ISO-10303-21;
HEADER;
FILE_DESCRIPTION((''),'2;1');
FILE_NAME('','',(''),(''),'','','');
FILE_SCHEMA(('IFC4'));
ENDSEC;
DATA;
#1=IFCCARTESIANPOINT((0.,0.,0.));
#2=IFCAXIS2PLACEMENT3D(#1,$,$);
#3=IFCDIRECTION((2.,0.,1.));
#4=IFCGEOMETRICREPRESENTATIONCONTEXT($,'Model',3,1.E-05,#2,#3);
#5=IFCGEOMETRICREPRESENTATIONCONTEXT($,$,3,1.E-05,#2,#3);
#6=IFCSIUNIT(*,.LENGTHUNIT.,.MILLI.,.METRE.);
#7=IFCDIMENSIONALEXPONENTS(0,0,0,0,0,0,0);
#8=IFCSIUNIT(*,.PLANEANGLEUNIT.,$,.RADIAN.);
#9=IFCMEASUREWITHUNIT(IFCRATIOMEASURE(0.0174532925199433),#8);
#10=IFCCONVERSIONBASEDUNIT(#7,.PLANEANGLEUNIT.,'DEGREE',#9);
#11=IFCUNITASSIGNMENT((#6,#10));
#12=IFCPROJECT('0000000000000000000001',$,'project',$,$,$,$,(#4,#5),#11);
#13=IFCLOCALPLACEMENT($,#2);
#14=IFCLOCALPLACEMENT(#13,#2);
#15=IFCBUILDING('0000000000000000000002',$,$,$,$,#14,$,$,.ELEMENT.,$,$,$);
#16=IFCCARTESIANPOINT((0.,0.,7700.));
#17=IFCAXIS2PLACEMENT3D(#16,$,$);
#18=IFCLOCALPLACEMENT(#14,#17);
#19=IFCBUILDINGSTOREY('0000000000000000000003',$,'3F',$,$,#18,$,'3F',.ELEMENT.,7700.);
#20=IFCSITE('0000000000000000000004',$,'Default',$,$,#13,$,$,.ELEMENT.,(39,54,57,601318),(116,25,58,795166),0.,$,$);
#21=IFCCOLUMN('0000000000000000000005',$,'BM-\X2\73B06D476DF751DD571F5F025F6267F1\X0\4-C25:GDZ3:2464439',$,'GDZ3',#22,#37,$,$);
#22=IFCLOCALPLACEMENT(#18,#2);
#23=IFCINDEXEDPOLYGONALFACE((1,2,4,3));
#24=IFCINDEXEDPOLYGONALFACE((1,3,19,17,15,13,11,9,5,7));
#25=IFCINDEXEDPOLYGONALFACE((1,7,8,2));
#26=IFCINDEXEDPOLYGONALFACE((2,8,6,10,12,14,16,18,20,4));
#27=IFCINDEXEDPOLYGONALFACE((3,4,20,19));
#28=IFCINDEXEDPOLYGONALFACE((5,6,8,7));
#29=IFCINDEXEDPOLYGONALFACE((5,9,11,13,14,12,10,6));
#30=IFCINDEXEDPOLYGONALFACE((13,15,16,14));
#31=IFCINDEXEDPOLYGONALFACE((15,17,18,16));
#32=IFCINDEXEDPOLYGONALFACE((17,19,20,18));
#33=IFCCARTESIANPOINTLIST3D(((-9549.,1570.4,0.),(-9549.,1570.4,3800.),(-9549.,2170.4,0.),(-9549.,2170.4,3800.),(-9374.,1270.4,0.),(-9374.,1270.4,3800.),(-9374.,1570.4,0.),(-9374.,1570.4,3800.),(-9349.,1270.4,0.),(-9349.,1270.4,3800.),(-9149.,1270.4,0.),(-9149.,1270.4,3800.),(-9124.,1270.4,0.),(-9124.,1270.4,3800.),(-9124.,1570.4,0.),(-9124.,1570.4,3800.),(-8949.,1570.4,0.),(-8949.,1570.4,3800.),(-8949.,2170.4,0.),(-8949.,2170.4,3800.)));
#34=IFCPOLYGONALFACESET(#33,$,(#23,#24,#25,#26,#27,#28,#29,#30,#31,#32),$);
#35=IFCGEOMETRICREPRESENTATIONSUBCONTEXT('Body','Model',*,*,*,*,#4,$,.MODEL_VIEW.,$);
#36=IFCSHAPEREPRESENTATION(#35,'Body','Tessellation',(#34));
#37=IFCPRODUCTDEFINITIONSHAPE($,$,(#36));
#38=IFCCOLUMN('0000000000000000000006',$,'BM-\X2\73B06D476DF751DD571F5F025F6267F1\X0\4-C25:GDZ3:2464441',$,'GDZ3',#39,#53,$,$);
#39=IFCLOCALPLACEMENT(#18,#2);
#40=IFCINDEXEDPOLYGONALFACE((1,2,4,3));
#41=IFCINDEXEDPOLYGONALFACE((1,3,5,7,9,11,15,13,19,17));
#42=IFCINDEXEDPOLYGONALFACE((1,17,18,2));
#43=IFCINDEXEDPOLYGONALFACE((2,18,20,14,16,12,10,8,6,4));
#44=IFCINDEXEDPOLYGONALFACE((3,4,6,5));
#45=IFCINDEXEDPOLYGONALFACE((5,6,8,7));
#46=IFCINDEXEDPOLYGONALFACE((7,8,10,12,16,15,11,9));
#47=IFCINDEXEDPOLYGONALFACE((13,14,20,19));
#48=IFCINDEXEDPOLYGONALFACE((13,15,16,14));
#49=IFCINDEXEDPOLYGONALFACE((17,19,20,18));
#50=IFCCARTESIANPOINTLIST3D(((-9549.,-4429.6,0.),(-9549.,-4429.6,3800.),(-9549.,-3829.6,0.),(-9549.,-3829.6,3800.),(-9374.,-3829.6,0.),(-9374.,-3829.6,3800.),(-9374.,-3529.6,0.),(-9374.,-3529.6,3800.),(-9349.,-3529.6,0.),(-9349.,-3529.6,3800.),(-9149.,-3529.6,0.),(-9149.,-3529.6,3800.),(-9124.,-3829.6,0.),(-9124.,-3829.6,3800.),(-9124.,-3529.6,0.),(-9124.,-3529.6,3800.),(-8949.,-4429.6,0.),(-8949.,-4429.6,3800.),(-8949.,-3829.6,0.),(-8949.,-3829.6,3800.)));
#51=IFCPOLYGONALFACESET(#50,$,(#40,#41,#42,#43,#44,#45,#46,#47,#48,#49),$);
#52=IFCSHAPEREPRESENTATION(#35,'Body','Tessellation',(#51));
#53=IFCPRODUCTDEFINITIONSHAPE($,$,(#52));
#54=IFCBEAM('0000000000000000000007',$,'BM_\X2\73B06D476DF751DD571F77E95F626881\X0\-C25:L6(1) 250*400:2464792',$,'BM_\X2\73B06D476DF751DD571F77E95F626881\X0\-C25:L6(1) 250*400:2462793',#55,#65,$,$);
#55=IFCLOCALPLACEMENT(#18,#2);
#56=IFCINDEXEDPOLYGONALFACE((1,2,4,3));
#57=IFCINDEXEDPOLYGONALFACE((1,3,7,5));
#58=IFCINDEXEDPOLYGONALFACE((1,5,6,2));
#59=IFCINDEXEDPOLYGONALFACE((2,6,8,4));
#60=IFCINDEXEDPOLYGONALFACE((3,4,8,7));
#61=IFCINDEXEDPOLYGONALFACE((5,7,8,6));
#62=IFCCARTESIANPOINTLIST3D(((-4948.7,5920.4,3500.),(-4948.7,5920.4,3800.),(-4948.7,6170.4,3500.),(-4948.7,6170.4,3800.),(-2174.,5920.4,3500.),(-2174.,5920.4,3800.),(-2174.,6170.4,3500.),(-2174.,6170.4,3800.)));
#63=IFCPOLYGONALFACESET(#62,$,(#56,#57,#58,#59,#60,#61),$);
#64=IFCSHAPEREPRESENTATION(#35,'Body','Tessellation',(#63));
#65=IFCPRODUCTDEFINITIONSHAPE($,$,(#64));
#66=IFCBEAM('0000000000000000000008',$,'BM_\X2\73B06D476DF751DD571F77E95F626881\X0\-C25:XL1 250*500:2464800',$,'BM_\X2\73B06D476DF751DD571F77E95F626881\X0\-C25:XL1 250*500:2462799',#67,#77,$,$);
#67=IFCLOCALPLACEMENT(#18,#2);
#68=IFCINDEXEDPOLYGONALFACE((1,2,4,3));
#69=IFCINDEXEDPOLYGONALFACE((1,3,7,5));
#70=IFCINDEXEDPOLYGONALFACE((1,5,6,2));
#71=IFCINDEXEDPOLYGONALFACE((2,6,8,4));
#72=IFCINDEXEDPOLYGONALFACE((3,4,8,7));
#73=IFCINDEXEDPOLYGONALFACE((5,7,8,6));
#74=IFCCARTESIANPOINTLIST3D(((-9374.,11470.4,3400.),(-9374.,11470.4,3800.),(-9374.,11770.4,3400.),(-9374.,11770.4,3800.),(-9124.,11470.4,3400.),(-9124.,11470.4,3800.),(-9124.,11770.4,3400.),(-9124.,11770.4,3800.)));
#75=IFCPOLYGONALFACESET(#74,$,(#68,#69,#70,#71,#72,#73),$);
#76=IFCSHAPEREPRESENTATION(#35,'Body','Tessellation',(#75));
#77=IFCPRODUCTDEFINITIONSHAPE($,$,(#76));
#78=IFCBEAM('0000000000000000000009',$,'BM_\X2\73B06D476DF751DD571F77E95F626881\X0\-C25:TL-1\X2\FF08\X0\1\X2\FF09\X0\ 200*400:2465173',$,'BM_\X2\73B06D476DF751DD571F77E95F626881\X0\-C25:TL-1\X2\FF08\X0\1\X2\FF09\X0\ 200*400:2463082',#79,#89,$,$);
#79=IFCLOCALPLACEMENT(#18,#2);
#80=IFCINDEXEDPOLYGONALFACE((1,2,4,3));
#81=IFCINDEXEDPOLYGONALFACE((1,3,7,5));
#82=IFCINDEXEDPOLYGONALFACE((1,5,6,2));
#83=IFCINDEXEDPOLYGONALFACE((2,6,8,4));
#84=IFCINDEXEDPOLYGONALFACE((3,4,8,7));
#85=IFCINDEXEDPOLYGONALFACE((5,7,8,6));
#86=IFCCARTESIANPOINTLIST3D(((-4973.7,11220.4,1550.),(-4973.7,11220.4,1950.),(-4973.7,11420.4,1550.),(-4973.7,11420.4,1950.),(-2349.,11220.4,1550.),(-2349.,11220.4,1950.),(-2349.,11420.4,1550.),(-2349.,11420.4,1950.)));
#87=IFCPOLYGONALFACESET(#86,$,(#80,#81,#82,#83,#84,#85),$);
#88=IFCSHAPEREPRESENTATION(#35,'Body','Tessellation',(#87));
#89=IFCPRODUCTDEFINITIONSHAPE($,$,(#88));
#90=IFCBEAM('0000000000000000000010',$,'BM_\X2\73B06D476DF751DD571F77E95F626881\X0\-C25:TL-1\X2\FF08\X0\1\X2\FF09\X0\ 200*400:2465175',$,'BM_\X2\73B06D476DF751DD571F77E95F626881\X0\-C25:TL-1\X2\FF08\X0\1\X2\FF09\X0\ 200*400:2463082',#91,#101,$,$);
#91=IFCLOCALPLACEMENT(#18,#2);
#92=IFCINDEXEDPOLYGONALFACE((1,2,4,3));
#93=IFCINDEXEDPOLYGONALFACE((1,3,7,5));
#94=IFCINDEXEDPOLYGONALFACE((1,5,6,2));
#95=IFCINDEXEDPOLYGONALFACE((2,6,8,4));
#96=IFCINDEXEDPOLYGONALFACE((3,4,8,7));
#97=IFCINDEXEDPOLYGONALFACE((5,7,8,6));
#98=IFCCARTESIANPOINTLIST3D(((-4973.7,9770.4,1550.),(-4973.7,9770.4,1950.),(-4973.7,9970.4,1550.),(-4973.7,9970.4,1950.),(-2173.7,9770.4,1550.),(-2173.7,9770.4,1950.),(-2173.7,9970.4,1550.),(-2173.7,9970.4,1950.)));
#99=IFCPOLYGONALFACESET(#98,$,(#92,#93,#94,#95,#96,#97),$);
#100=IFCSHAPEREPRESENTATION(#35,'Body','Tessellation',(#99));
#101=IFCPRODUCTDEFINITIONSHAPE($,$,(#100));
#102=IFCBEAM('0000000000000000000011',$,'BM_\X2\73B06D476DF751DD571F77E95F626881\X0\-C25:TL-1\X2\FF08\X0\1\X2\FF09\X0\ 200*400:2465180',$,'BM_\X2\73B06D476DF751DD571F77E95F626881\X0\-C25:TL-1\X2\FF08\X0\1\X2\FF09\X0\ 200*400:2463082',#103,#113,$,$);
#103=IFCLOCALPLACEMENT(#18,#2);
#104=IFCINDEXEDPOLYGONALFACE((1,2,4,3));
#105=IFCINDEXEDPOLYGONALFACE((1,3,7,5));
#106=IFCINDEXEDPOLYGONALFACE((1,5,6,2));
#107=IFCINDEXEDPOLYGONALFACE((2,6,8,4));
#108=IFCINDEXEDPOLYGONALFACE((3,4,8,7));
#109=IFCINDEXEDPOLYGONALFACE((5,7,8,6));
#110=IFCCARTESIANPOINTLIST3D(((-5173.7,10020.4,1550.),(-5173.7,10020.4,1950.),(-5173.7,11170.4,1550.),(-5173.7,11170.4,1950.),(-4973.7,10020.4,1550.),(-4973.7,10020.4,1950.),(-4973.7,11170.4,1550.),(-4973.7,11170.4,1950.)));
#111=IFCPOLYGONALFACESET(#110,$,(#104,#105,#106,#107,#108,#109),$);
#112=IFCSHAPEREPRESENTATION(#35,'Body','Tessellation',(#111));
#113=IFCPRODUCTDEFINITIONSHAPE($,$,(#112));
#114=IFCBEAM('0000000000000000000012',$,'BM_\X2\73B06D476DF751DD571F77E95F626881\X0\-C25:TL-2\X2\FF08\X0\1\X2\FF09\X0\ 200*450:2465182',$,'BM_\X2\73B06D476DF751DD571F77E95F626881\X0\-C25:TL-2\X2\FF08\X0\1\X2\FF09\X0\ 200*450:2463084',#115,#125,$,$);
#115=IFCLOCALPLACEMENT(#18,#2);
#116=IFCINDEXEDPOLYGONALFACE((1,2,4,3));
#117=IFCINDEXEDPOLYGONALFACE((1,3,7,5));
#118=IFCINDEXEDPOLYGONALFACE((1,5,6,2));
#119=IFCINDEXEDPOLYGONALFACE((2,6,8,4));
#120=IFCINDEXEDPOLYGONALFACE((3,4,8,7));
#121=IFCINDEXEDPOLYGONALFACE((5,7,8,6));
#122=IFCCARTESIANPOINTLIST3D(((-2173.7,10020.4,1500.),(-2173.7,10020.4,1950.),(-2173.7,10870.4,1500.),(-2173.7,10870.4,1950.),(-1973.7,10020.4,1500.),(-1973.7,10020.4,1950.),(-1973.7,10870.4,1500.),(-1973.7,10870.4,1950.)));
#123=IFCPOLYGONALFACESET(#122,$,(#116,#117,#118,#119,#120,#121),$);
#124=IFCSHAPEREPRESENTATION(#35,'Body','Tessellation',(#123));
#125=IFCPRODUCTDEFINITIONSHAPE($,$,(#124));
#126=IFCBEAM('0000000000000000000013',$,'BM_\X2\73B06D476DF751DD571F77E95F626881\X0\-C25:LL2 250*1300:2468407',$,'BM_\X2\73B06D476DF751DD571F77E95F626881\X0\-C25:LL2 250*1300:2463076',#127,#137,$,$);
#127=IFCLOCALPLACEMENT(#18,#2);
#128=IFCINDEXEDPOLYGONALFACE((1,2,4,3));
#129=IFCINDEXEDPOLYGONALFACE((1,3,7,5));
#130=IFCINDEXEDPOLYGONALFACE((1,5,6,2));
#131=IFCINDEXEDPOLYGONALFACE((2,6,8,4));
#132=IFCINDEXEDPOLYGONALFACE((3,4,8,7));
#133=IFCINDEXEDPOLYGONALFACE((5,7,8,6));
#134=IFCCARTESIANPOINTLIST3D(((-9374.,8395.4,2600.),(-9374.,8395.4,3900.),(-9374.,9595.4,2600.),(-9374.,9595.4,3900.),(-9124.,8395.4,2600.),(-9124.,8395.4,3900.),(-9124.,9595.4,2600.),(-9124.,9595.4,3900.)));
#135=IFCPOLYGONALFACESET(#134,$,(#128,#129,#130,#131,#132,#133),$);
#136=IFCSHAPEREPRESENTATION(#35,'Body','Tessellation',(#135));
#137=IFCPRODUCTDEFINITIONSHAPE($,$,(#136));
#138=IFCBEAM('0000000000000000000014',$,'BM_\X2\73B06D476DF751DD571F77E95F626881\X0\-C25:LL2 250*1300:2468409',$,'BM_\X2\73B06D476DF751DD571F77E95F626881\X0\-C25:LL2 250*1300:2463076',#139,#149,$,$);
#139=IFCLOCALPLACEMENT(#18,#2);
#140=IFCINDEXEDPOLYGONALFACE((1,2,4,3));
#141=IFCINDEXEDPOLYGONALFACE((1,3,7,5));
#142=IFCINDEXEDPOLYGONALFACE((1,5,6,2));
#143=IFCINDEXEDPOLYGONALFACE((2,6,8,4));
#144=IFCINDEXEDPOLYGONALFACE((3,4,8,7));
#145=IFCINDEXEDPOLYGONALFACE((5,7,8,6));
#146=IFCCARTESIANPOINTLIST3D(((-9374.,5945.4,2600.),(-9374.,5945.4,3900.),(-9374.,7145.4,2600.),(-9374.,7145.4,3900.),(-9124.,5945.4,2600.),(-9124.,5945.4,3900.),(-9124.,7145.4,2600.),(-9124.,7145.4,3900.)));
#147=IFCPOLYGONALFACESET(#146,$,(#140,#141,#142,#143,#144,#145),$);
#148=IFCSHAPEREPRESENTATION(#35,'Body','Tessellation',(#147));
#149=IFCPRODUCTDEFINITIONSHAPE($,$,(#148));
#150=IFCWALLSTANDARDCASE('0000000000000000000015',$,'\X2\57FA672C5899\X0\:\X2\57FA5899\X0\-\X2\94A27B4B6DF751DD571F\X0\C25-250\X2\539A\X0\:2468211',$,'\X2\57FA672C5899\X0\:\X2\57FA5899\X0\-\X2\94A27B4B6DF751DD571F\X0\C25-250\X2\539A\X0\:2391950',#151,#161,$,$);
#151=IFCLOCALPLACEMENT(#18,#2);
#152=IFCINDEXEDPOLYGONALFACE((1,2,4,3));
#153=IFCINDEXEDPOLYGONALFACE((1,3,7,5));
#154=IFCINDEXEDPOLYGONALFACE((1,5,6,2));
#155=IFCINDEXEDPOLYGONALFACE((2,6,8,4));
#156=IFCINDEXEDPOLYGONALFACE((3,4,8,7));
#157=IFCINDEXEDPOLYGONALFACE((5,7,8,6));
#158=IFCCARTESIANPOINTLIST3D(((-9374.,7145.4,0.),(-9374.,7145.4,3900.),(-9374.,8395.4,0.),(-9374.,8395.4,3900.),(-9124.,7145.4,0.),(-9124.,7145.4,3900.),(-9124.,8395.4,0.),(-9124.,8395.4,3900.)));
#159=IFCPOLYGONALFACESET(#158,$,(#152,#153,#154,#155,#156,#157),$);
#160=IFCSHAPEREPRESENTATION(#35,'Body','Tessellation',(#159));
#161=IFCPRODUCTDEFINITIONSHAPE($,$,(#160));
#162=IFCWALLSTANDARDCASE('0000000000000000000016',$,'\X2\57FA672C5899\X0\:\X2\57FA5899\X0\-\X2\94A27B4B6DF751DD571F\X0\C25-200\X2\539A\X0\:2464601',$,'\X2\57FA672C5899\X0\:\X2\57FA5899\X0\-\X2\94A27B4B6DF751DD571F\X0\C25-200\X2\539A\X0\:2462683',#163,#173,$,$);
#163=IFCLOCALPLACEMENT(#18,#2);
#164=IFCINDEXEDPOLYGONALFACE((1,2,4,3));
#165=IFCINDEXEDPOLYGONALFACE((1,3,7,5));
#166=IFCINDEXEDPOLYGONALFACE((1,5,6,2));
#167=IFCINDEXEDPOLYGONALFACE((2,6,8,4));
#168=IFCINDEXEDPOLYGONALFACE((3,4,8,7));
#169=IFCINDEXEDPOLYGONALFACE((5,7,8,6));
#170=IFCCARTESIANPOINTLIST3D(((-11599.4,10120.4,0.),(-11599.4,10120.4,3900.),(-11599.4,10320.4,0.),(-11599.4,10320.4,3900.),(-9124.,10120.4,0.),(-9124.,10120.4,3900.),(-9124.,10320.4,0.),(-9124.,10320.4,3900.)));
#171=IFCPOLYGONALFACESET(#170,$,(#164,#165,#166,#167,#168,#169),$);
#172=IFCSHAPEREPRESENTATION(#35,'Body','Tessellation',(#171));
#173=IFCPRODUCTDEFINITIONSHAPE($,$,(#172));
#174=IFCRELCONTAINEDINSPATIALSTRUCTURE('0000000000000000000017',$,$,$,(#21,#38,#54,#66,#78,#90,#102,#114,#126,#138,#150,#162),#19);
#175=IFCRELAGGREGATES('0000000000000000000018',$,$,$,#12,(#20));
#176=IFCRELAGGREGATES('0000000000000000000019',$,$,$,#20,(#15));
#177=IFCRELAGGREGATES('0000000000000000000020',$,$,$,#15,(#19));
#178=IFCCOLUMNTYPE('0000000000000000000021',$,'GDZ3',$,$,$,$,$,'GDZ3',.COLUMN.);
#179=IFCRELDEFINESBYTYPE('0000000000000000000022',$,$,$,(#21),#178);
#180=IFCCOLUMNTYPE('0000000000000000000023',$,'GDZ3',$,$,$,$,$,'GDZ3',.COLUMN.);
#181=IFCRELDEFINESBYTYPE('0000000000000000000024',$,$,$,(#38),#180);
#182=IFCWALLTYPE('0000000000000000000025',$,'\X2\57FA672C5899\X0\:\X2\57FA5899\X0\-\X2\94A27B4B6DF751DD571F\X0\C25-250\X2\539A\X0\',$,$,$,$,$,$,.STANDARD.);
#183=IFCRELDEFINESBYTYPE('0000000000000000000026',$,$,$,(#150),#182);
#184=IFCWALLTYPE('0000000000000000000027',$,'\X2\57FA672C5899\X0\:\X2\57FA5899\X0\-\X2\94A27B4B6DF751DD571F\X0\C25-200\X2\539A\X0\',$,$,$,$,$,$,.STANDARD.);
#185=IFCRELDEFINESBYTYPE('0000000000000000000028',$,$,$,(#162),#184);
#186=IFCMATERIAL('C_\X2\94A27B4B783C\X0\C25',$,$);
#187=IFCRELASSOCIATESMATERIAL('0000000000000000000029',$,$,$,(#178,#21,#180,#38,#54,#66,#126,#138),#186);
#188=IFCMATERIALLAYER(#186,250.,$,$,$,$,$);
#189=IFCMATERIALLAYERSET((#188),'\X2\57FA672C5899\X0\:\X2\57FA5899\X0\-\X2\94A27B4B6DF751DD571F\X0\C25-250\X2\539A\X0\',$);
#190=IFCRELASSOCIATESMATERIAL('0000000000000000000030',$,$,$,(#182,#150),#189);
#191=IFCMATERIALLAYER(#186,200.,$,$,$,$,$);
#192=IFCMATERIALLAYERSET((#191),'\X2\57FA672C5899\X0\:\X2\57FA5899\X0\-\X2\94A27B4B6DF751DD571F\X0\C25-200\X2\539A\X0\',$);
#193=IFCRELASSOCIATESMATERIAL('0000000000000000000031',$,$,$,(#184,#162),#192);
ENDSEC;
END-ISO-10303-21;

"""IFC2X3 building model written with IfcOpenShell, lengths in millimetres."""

from ifc_helpers import new_model, entity, si_unit, converted_unit, direction, frame, frame_2d, origin, origin_2d_with_axis, place, context, subcontext, project, spatial, polyline, rectangle, outline, extrude, source, transform, mapped, material, layer, layer_set, layer_usage, type_object, type_shapes, element, save


model = new_model("IFC2X3")

# Units and contexts
model_context = context("Model", 3, precision=1e-05, world=origin(), true_north=direction((2.0, 0.0, 1.0)))
context_of_model = context(None, 3, precision=1e-05, world=origin(), true_north=direction((2.0, 0.0, 1.0)))
body_context = subcontext(model_context, "Body", "Model", "MODEL_VIEW")
ifc_project = project(units=[si_unit("LENGTHUNIT", "METRE", prefix="MILLI"), converted_unit("PLANEANGLEUNIT", "DEGREE", entity("IfcRatioMeasure", 0.0174532925199433), si_unit("PLANEANGLEUNIT", "RADIAN"), dimensions=[0, 0, 0, 0, 0, 0, 0])], contexts=[model_context, context_of_model])

# Site, building, storey
site_placement = place(None, origin())
site = spatial("IfcSite", under=ifc_project, at=site_placement, Name="Default", CompositionType="ELEMENT", RefLatitude=(39, 54, 57, 601318), RefLongitude=(116, 25, 58, 795166), RefElevation=0.0)
building_placement = place(site_placement, origin())
building = spatial("IfcBuilding", under=site, at=building_placement, CompositionType="ELEMENT")
storey_placement = place(building_placement, frame((0.0, 0.0, 7700.0)))
storey = spatial("IfcBuildingStorey", under=building, at=storey_placement, Name="3F", LongName="3F", CompositionType="ELEMENT", Elevation=7700.0)

# Columns
ifc_material = material(Name="C_钢筋砼C25")
column_type_1 = type_object("IfcColumnType", Name="GDZ3", ElementType="GDZ3", PredefinedType="COLUMN", material=ifc_material)
shared_shape_1 = source(origin(), body_context, "Body", "SweptSolid", [
    extrude(outline(polyline([(0.0, -300.0), (600.0, -300.0), (600.0, 300.0), (0.0, 300.0), (0.0, 125.0), (-300.0, 125.0), (-300.0, 100.0), (-300.0, -100.0), (-300.0, -125.0), (0.0, -125.0), (0.0, -300.0)])), frame((-9249.0, 1570.4, 7700.0), z_axis=(0.0, 0.0, 1.0), x_axis=(0.0, 1.0, 0.0)), (0.0, 0.0, 1.0), 3800.0),
])
type_shapes(column_type_1, [shared_shape_1])
column_1_placement = place(storey_placement, frame((0.0, 0.0, -7700.0)))
element("IfcColumn", 1, at=column_1_placement, inside=storey, type_object=column_type_1, material=ifc_material, Name="BM-现浇混凝土异形柱4-C25:GDZ3:2464439", ObjectType="GDZ3", context=body_context, shape_type="MappedRepresentation", body=[
    mapped(shared_shape_1, transform((0.0, 0.0, 0.0), scale=1.0)),
])
column_type_2 = type_object("IfcColumnType", Name="GDZ3", ElementType="GDZ3", PredefinedType="COLUMN", material=ifc_material)
shared_shape_2 = source(origin(), body_context, "Body", "SweptSolid", [
    extrude(outline(polyline([(0.0, -300.0), (600.0, -300.0), (600.0, 300.0), (0.0, 300.0), (0.0, 125.0), (-300.0, 125.0), (-300.0, 100.0), (-300.0, -100.0), (-300.0, -125.0), (0.0, -125.0), (0.0, -300.0)])), frame((-9249.0, -3829.6, 7700.0), z_axis=(0.0, 0.0, 1.0), x_axis=(0.0, -1.0, 0.0)), (0.0, 0.0, 1.0), 3800.0),
])
type_shapes(column_type_2, [shared_shape_2])
column_2_placement = place(storey_placement, frame((0.0, 0.0, -7700.0)))
element("IfcColumn", 2, at=column_2_placement, inside=storey, type_object=column_type_2, material=ifc_material, Name="BM-现浇混凝土异形柱4-C25:GDZ3:2464441", ObjectType="GDZ3", context=body_context, shape_type="MappedRepresentation", body=[
    mapped(shared_shape_2, transform((0.0, 0.0, 0.0), scale=1.0)),
])

# Beams
beam_1_placement = place(storey_placement, frame((-5073.7, 6045.4, 3900.0)))
element("IfcBeam", 3, at=beam_1_placement, inside=storey, material=ifc_material, Name="BM_现浇混凝土矩形梁-C25:L6(1) 250*400:2464792", ObjectType="BM_现浇混凝土矩形梁-C25:L6(1) 250*400:2462793", context=body_context, shape_type="SweptSolid", body=[
    extrude(rectangle(XDim=300.0, YDim=250.0, at=frame_2d((0.0, 0.0), x_axis=(1.0, 0.0))), frame((125.0, 0.0, -250.0), z_axis=(1.0, 0.0, 0.0), x_axis=(0.0, 0.0, -1.0)), (0.0, 0.0, 1.0), 2774.6),
])
beam_2_placement = place(storey_placement, frame((-9249.0, 11170.4, 3900.0), z_axis=(0.0, 0.0, 1.0), x_axis=(0.0, 1.0, 0.0)))
element("IfcBeam", 4, at=beam_2_placement, inside=storey, material=ifc_material, Name="BM_现浇混凝土矩形梁-C25:XL1 250*500:2464800", ObjectType="BM_现浇混凝土矩形梁-C25:XL1 250*500:2462799", context=body_context, shape_type="SweptSolid", body=[
    extrude(rectangle(XDim=400.0, YDim=250.0, at=origin_2d_with_axis()), frame((300.0, 0.0, -300.0), z_axis=(1.0, 0.0, 0.0), x_axis=(0.0, 0.0, -1.0)), (0.0, 0.0, 1.0), 300.0),
])
beam_3_placement = place(storey_placement, frame((-5073.7, 11320.4, 1950.0)))
element("IfcBeam", 5, at=beam_3_placement, inside=storey, Name="BM_现浇混凝土矩形梁-C25:TL-1（1） 200*400:2465173", ObjectType="BM_现浇混凝土矩形梁-C25:TL-1（1） 200*400:2463082", context=body_context, shape_type="SweptSolid", body=[
    extrude(rectangle(XDim=400.0, YDim=200.0, at=frame_2d((0.0, 0.0), x_axis=(1.0, 0.0))), frame((100.0, 0.0, -200.0), z_axis=(1.0, 0.0, 0.0), x_axis=(0.0, 0.0, -1.0)), (0.0, 0.0, 1.0), 2624.6),
])
beam_4_placement = place(storey_placement, frame((-5073.7, 9870.4, 1950.0)))
element("IfcBeam", 6, at=beam_4_placement, inside=storey, Name="BM_现浇混凝土矩形梁-C25:TL-1（1） 200*400:2465175", ObjectType="BM_现浇混凝土矩形梁-C25:TL-1（1） 200*400:2463082", context=body_context, shape_type="SweptSolid", body=[
    extrude(rectangle(XDim=400.0, YDim=200.0, at=frame_2d((0.0, 0.0), x_axis=(1.0, 0.0))), frame((100.0, 0.0, -200.0), z_axis=(1.0, 0.0, 0.0), x_axis=(0.0, 0.0, -1.0)), (0.0, 0.0, 1.0), 2800.0),
])
beam_5_placement = place(storey_placement, frame((-5073.7, 11170.4, 1950.0), z_axis=(0.0, 0.0, 1.0), x_axis=(0.0, -1.0, 0.0)))
element("IfcBeam", 7, at=beam_5_placement, inside=storey, Name="BM_现浇混凝土矩形梁-C25:TL-1（1） 200*400:2465180", ObjectType="BM_现浇混凝土矩形梁-C25:TL-1（1） 200*400:2463082", context=body_context, shape_type="SweptSolid", body=[
    extrude(rectangle(XDim=400.0, YDim=200.0, at=origin_2d_with_axis()), frame((0.0, 0.0, -200.0), z_axis=(1.0, 0.0, 0.0), x_axis=(0.0, 0.0, -1.0)), (0.0, 0.0, 1.0), 1150.0),
])
beam_6_placement = place(storey_placement, frame((-2073.7, 11195.4, 1950.0), z_axis=(0.0, 0.0, 1.0), x_axis=(0.0, -1.0, 0.0)))
element("IfcBeam", 8, at=beam_6_placement, inside=storey, Name="BM_现浇混凝土矩形梁-C25:TL-2（1） 200*450:2465182", ObjectType="BM_现浇混凝土矩形梁-C25:TL-2（1） 200*450:2463084", context=body_context, shape_type="SweptSolid", body=[
    extrude(rectangle(XDim=450.0, YDim=200.0, at=frame_2d((0.0, 0.0), x_axis=(1.0, 0.0))), frame((325.0, 0.0, -225.0), z_axis=(1.0, 0.0, 0.0), x_axis=(0.0, 0.0, -1.0)), (0.0, 0.0, 1.0), 850.0),
])
beam_7_placement = place(storey_placement, frame((-9249.0, 9795.4, 3900.0), z_axis=(0.0, 0.0, 1.0), x_axis=(0.0, -1.0, 0.0)))
element("IfcBeam", 9, at=beam_7_placement, inside=storey, material=ifc_material, Name="BM_现浇混凝土矩形梁-C25:LL2 250*1300:2468407", ObjectType="BM_现浇混凝土矩形梁-C25:LL2 250*1300:2463076", context=body_context, shape_type="SweptSolid", body=[
    extrude(rectangle(XDim=1300.0, YDim=250.0, at=frame_2d((0.0, 0.0), x_axis=(1.0, 0.0))), frame((200.0, 0.0, -650.0), z_axis=(1.0, 0.0, 0.0), x_axis=(0.0, 0.0, -1.0)), (0.0, 0.0, 1.0), 1200.0),
])
beam_8_placement = place(storey_placement, frame((-9249.0, 7345.4, 3900.0), z_axis=(0.0, 0.0, 1.0), x_axis=(0.0, -1.0, 0.0)))
element("IfcBeam", 10, at=beam_8_placement, inside=storey, material=ifc_material, Name="BM_现浇混凝土矩形梁-C25:LL2 250*1300:2468409", ObjectType="BM_现浇混凝土矩形梁-C25:LL2 250*1300:2463076", context=body_context, shape_type="SweptSolid", body=[
    extrude(rectangle(XDim=1300.0, YDim=250.0, at=frame_2d((0.0, 0.0), x_axis=(1.0, 0.0))), frame((200.0, 0.0, -650.0), z_axis=(1.0, 0.0, 0.0), x_axis=(0.0, 0.0, -1.0)), (0.0, 0.0, 1.0), 1200.0),
])

# Walls
ifc_layer_1 = layer(ifc_material, 250.0)
ifc_layer_set_1 = layer_set([ifc_layer_1], Name="基本墙:基墙-钢筋混凝土C25-250厚")
ifc_layer_usage_1 = layer_usage(ifc_layer_set_1, "AXIS2", "NEGATIVE", 125.0)
wall_type_1 = type_object("IfcWallType", Name="基本墙:基墙-钢筋混凝土C25-250厚", PredefinedType="STANDARD", material=ifc_layer_set_1)
wall_1_placement = place(storey_placement, frame((-9249.0, 8395.4, 0.0), z_axis=(0.0, 0.0, 1.0), x_axis=(0.0, -1.0, 0.0)))
element("IfcWallStandardCase", 11, at=wall_1_placement, inside=storey, type_object=wall_type_1, material=ifc_layer_usage_1, Name="基本墙:基墙-钢筋混凝土C25-250厚:2468211", ObjectType="基本墙:基墙-钢筋混凝土C25-250厚:2391950", context=body_context, shape_type="SweptSolid", body=[
    extrude(rectangle(XDim=1250.0, YDim=250.0, at=frame_2d((625.0, 0.0), x_axis=(-1.0, 0.0))), origin(), (0.0, 0.0, 1.0), 3900.0),
])
ifc_layer_2 = layer(ifc_material, 200.0)
ifc_layer_set_2 = layer_set([ifc_layer_2], Name="基本墙:基墙-钢筋混凝土C25-200厚")
ifc_layer_usage_2 = layer_usage(ifc_layer_set_2, "AXIS2", "NEGATIVE", 100.0)
wall_type_2 = type_object("IfcWallType", Name="基本墙:基墙-钢筋混凝土C25-200厚", PredefinedType="STANDARD", material=ifc_layer_set_2)
wall_2_placement = place(storey_placement, frame((-9124.0, 10220.4, 0.0), z_axis=(0.0, 0.0, 1.0), x_axis=(-1.0, 0.0, 0.0)))
element("IfcWallStandardCase", 12, at=wall_2_placement, inside=storey, type_object=wall_type_2, material=ifc_layer_usage_2, Name="基本墙:基墙-钢筋混凝土C25-200厚:2464601", ObjectType="基本墙:基墙-钢筋混凝土C25-200厚:2462683", context=body_context, shape_type="SweptSolid", body=[
    extrude(rectangle(XDim=2475.4, YDim=200.0, at=frame_2d((1237.7, 0.0), x_axis=(-1.0, 0.0))), origin(), (0.0, 0.0, 1.0), 3900.0),
])

save(model, "model.ifc")
